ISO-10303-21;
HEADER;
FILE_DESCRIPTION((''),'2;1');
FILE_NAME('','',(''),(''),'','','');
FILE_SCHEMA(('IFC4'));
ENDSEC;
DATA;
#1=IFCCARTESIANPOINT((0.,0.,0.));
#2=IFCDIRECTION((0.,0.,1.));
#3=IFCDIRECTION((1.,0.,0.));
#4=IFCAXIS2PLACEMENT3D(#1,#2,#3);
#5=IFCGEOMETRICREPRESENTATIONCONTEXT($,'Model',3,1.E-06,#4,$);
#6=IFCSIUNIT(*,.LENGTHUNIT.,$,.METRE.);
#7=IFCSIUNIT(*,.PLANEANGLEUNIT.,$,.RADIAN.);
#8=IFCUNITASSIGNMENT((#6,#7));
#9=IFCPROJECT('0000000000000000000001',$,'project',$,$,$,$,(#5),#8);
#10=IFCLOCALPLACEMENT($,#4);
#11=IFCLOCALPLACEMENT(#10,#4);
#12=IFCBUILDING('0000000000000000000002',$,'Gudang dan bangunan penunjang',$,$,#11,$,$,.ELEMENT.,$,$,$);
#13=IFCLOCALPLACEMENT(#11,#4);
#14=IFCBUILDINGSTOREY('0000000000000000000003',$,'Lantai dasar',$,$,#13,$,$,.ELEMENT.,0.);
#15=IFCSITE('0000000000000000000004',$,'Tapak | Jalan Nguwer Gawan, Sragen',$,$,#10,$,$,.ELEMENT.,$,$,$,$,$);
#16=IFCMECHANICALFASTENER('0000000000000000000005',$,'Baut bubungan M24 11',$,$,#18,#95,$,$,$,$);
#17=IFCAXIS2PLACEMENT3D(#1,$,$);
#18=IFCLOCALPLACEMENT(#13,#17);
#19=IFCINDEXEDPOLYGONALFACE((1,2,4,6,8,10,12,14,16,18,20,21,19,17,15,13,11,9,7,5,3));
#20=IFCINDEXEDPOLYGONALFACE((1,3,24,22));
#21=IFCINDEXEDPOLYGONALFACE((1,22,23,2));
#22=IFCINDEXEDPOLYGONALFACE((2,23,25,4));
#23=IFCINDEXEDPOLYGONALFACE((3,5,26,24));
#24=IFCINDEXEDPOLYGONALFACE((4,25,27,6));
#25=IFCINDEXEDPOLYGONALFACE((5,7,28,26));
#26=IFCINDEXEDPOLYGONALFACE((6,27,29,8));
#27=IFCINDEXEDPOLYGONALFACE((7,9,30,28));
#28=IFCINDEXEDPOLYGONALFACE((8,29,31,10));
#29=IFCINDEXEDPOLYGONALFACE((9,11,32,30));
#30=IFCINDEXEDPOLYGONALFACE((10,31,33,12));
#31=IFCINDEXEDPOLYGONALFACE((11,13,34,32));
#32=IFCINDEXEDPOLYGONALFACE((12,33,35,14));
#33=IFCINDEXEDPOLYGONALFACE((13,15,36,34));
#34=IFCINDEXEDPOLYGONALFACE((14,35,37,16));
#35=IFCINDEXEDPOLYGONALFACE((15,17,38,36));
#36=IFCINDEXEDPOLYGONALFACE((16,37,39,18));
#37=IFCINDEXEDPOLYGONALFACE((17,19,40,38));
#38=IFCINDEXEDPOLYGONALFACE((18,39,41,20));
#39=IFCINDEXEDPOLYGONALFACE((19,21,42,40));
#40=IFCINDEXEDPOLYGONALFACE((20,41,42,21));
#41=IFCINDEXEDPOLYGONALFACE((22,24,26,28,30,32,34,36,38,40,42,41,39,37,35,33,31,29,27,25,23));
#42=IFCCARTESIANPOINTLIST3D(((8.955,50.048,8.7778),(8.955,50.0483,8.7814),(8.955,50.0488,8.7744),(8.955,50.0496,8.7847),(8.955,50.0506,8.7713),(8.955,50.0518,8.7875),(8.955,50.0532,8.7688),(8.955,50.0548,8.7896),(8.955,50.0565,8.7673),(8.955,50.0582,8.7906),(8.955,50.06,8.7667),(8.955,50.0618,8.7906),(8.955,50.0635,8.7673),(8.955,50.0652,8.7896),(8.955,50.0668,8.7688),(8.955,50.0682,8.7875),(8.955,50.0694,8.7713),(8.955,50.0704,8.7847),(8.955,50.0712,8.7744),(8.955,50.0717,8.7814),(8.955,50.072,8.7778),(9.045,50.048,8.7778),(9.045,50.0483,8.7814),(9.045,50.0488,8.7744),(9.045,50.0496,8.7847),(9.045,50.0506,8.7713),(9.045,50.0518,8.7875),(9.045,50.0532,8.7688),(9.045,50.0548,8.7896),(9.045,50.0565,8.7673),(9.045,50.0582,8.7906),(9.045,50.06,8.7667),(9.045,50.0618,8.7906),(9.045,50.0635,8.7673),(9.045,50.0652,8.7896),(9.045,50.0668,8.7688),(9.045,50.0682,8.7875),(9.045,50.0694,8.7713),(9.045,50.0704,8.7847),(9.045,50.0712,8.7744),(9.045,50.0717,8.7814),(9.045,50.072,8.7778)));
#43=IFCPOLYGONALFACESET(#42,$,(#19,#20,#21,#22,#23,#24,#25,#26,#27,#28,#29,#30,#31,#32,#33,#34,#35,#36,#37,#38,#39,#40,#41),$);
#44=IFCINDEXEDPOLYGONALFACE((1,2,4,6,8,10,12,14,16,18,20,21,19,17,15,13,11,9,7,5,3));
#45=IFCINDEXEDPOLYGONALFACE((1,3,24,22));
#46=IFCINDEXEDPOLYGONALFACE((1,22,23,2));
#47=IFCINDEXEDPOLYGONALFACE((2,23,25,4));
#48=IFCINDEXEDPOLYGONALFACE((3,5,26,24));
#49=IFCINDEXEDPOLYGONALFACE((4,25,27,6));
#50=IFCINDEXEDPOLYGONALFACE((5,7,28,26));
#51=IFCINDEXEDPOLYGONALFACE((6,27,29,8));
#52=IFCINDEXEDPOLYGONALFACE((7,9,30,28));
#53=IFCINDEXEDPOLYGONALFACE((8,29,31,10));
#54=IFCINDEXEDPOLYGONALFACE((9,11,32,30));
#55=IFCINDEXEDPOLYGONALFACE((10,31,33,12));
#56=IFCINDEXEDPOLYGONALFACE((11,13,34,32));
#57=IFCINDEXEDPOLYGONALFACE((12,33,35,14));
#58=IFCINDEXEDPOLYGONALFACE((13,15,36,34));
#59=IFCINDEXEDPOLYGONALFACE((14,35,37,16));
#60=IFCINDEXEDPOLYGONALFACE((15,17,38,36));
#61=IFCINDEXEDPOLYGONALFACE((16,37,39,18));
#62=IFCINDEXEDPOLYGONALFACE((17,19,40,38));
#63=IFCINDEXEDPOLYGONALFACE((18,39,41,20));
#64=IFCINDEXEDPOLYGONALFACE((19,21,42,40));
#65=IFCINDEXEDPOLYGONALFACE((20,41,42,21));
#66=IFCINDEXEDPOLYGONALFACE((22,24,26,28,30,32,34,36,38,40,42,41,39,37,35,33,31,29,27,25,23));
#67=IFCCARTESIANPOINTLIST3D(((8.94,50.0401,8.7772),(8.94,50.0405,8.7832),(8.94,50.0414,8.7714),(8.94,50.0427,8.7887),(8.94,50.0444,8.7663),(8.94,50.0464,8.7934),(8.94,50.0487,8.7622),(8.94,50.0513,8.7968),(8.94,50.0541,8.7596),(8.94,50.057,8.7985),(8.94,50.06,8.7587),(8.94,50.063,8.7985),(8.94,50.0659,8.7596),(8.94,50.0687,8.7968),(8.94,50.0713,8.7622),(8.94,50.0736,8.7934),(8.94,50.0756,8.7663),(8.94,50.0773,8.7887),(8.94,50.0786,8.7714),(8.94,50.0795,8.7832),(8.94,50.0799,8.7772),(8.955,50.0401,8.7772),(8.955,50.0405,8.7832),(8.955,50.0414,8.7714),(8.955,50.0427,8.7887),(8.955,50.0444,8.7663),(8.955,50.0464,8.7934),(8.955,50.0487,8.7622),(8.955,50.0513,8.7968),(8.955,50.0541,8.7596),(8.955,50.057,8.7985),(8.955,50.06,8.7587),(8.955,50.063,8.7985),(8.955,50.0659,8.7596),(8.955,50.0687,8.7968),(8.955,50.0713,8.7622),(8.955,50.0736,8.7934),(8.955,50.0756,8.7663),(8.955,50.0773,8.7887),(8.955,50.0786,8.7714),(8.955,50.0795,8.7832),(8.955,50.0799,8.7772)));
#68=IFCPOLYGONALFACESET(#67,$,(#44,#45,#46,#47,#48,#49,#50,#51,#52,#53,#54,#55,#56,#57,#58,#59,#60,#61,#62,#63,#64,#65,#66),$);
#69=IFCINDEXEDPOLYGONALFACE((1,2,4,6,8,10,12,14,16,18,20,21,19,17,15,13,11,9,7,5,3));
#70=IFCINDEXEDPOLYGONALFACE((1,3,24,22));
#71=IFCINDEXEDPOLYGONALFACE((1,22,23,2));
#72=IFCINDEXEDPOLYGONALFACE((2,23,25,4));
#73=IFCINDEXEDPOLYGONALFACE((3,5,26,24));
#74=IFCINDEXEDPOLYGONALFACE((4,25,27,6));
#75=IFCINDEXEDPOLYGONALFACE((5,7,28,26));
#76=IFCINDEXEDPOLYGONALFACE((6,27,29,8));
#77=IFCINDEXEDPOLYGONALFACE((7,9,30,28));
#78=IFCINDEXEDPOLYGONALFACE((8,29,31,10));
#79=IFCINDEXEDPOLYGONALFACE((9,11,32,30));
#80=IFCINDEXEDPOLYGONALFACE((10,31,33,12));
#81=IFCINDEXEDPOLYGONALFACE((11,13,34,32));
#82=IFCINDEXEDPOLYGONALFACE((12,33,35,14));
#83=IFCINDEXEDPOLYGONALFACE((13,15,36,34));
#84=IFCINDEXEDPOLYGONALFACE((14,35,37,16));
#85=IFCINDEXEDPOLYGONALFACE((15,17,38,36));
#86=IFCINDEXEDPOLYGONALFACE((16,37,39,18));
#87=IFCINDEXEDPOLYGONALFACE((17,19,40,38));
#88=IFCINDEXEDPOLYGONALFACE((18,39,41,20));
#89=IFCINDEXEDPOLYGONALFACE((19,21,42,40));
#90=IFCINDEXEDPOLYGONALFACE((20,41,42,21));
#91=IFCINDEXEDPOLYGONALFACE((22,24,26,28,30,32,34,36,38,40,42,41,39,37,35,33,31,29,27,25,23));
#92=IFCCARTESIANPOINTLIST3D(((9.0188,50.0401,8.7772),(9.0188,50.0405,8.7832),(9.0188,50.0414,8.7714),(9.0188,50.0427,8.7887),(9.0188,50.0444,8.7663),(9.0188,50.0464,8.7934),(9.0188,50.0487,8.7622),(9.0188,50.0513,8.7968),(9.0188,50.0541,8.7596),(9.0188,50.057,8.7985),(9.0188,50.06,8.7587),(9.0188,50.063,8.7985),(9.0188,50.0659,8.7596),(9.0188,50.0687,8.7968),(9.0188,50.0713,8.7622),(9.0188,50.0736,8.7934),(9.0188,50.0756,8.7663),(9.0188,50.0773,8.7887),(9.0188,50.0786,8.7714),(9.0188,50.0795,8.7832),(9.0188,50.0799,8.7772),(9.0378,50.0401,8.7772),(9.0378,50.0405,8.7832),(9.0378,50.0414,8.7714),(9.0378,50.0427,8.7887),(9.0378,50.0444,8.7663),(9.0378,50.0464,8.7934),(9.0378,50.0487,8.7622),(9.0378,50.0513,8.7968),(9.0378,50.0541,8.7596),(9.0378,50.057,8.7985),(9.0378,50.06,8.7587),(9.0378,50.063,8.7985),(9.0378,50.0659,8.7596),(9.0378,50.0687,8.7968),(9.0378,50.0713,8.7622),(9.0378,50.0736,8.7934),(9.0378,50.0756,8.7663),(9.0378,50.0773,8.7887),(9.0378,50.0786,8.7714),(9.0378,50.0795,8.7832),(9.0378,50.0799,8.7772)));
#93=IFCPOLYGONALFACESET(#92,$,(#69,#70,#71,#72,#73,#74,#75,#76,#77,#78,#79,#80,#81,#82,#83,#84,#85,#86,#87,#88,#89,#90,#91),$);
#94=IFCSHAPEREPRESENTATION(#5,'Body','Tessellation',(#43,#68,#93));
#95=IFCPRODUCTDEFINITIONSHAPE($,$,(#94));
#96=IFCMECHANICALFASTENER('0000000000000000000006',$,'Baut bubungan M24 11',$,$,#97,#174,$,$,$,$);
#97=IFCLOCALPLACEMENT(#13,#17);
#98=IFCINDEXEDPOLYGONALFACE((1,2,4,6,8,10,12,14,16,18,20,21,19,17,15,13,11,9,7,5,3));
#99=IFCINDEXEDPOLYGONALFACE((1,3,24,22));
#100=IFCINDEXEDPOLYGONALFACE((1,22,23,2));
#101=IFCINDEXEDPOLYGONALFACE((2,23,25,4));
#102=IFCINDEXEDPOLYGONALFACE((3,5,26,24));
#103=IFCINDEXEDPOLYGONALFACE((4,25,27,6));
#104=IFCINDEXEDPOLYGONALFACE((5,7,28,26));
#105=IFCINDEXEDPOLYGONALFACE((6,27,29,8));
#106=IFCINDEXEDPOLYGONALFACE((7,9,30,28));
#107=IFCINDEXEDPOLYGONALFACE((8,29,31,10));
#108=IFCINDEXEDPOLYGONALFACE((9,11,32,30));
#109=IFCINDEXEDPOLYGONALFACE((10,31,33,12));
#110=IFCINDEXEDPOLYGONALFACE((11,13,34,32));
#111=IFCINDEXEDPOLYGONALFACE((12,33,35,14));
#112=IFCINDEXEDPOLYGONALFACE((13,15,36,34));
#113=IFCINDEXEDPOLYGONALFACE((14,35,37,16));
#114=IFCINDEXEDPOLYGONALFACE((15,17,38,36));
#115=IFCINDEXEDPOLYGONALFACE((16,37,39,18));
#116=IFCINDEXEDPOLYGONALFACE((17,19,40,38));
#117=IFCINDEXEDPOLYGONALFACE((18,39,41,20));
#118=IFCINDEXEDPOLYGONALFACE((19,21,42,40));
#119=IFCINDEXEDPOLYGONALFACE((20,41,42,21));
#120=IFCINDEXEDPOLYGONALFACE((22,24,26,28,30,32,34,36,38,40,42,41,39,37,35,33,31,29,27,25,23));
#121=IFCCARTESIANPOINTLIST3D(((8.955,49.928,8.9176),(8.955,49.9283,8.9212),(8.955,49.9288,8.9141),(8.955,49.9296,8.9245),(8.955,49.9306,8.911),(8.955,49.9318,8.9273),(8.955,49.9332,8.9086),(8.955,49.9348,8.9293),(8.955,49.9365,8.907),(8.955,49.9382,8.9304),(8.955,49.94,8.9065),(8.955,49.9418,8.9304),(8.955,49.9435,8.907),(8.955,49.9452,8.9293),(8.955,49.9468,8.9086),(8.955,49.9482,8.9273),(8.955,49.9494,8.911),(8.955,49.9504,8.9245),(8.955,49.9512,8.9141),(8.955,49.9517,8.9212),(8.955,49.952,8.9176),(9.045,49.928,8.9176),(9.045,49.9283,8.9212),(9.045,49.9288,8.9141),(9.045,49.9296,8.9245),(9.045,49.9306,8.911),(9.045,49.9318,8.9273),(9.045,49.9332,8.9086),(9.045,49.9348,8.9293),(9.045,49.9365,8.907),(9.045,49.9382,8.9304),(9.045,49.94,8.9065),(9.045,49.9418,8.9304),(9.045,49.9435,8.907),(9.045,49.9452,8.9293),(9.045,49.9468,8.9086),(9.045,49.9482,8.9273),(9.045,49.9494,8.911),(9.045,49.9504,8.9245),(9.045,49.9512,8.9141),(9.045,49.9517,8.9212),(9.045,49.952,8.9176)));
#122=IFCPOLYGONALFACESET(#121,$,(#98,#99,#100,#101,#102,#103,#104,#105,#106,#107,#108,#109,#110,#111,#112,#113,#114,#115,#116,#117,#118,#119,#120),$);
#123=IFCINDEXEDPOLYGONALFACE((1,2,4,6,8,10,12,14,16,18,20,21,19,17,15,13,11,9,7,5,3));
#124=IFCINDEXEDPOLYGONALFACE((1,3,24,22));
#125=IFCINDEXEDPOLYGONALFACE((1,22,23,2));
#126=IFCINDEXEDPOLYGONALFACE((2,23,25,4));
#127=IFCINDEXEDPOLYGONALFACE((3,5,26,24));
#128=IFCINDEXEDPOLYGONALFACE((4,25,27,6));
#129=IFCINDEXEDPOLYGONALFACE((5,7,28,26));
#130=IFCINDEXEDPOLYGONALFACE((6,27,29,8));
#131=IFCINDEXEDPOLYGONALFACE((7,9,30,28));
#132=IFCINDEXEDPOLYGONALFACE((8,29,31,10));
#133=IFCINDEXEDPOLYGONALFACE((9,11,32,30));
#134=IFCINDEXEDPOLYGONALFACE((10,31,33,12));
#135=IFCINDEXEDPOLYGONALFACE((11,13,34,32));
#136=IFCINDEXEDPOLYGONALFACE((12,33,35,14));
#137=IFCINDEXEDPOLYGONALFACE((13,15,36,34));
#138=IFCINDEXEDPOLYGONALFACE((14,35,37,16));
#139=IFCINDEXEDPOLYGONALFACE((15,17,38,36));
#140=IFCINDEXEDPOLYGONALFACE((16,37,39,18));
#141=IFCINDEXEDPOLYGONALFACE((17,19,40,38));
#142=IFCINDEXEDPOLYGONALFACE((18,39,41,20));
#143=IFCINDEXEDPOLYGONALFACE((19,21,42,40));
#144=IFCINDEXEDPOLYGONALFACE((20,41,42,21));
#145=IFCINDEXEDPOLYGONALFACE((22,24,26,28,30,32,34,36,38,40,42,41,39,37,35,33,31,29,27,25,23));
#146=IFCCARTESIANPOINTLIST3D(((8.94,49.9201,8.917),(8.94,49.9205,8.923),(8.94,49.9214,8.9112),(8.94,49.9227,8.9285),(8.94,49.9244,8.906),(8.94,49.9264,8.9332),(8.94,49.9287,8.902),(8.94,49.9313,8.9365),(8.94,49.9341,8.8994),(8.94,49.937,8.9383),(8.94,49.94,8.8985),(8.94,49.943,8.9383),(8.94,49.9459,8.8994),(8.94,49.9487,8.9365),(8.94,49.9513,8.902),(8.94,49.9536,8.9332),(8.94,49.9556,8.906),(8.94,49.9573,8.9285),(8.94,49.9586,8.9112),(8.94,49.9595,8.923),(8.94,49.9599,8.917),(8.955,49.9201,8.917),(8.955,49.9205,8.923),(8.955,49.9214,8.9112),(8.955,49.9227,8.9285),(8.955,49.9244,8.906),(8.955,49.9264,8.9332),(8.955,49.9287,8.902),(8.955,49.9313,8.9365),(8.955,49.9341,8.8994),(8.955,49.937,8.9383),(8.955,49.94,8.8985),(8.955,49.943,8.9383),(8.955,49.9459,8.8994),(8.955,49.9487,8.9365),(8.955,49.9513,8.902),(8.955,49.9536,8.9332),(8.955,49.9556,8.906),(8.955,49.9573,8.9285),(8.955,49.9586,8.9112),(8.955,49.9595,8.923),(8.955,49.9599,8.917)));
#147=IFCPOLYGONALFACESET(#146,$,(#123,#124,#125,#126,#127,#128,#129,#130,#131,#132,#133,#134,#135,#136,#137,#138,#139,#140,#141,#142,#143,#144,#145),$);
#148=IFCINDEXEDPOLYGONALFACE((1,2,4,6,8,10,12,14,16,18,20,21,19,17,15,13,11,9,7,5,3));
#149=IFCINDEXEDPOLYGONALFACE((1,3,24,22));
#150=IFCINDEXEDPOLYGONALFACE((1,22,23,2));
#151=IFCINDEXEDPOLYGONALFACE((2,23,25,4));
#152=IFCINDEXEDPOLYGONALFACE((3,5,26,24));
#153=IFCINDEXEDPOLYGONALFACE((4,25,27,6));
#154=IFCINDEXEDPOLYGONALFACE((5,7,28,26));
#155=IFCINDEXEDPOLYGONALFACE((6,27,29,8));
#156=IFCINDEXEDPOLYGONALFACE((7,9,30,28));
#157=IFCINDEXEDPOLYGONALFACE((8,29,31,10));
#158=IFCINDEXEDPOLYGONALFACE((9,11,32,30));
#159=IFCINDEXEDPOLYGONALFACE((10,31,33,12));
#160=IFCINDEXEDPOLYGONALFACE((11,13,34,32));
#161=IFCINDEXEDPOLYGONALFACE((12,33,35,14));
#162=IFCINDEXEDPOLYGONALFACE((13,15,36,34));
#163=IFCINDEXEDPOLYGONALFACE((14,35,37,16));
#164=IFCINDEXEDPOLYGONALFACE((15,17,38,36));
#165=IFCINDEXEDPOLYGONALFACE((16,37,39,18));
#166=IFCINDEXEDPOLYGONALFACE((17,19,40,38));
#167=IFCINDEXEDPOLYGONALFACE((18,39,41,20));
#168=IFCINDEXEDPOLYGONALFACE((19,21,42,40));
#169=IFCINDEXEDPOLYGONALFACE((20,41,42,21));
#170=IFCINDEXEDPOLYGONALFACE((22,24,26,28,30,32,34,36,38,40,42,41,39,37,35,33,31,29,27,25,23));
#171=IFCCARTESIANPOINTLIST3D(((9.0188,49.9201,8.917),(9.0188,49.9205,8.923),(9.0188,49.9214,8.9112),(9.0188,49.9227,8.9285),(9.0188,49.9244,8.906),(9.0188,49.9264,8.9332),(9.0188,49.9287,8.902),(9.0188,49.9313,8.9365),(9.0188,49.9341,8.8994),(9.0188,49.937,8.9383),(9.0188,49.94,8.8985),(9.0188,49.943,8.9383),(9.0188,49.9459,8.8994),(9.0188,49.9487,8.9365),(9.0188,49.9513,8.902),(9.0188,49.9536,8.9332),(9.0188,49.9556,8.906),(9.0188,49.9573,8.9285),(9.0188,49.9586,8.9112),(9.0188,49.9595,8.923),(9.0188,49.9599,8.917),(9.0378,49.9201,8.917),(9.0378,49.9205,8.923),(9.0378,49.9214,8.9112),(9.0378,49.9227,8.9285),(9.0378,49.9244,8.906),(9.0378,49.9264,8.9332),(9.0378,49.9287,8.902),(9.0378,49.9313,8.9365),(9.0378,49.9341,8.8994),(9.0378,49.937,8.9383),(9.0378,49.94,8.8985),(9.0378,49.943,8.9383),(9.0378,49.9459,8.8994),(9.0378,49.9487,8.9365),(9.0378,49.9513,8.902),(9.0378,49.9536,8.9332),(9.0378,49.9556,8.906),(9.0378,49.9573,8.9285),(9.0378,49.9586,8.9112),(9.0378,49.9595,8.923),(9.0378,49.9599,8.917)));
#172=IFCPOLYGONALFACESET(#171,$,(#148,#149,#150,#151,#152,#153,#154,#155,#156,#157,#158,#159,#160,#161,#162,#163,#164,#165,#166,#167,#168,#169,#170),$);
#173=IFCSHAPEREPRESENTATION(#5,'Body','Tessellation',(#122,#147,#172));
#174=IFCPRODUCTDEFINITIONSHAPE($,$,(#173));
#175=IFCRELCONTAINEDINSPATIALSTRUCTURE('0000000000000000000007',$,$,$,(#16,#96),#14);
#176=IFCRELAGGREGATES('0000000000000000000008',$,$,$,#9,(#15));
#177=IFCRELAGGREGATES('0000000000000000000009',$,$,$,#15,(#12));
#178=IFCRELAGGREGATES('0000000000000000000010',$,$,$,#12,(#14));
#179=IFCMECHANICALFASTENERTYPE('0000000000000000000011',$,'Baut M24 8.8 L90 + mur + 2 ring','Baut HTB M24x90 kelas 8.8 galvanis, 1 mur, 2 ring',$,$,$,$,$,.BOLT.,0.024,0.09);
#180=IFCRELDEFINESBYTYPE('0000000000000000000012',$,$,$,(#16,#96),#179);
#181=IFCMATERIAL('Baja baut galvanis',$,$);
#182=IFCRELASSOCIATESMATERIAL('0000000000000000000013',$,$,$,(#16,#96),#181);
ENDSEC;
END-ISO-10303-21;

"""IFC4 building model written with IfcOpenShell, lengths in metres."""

from ifc_helpers import new_model, si_unit, frame, origin_with_axes, place, context, project, spatial, circle, extrude, source, transform, mapped, material, type_object, type_shapes, element, save


model = new_model("IFC4")

# Units and contexts
model_context = context("Model", 3, precision=1e-06, world=origin_with_axes())
ifc_project = project(units=[si_unit("LENGTHUNIT", "METRE"), si_unit("PLANEANGLEUNIT", "RADIAN")], contexts=[model_context])

# Site, building, storey
site_placement = place(None, origin_with_axes())
site = spatial("IfcSite", under=ifc_project, at=site_placement, Name="Tapak | Jalan Nguwer Gawan, Sragen", CompositionType="ELEMENT")
building_placement = place(site_placement, origin_with_axes())
building = spatial("IfcBuilding", under=site, at=building_placement, Name="Gudang dan bangunan penunjang", CompositionType="ELEMENT")
storey_placement = place(building_placement, origin_with_axes())
storey = spatial("IfcBuildingStorey", under=building, at=storey_placement, Name="Lantai dasar", CompositionType="ELEMENT", Elevation=0.0)

# Shared definitions
placement = place(None, origin_with_axes())

# Mechanical fasteners
ifc_material_1 = material(Name="Baja baut galvanis")
mechanical_fastener_type_1 = type_object("IfcMechanicalFastenerType", Name="Baut M24 8.8 L90 + mur + 2 ring", Description="Baut HTB M24x90 kelas 8.8 galvanis, 1 mur, 2 ring", NominalDiameter=0.024, NominalLength=0.09, PredefinedType="BOLT")
shared_shape_1 = source(origin_with_axes(), model_context, "Body", "SweptSolid", [
    extrude(circle(Radius=0.012), origin_with_axes(), (0.0, 0.0, 1.0), 0.09),
    extrude(circle(Radius=0.02), frame((0.0, 0.0, -0.015), z_axis=(0.0, 0.0, 1.0), x_axis=(1.0, 0.0, 0.0)), (0.0, 0.0, 1.0), 0.015),
    extrude(circle(Radius=0.02), frame((0.0, 0.0, 0.0638), z_axis=(0.0, 0.0, 1.0), x_axis=(1.0, 0.0, 0.0)), (0.0, 0.0, 1.0), 0.019),
])
type_shapes(mechanical_fastener_type_1, [shared_shape_1])
element("IfcMechanicalFastener", 1, at=placement, inside=storey, type_object=mechanical_fastener_type_1, material=ifc_material_1, Name="Baut bubungan M24 11", context=model_context, shape_type="MappedRepresentation", body=[
    mapped(shared_shape_1, transform((8.955, 50.06, 8.7787), x_axis=(0.0, 0.0, -1.0), y_axis=(0.0, 1.0, 0.0), z_axis=(1.0, 0.0, 0.0), scale=1.0)),
])
element("IfcMechanicalFastener", 2, at=placement, inside=storey, type_object=mechanical_fastener_type_1, material=ifc_material_1, Name="Baut bubungan M24 11", context=model_context, shape_type="MappedRepresentation", body=[
    mapped(shared_shape_1, transform((8.955, 49.94, 8.9185), x_axis=(0.0, 0.0, -1.0), y_axis=(0.0, 1.0, 0.0), z_axis=(1.0, 0.0, 0.0), scale=1.0)),
])

save(model, "model.ifc")
